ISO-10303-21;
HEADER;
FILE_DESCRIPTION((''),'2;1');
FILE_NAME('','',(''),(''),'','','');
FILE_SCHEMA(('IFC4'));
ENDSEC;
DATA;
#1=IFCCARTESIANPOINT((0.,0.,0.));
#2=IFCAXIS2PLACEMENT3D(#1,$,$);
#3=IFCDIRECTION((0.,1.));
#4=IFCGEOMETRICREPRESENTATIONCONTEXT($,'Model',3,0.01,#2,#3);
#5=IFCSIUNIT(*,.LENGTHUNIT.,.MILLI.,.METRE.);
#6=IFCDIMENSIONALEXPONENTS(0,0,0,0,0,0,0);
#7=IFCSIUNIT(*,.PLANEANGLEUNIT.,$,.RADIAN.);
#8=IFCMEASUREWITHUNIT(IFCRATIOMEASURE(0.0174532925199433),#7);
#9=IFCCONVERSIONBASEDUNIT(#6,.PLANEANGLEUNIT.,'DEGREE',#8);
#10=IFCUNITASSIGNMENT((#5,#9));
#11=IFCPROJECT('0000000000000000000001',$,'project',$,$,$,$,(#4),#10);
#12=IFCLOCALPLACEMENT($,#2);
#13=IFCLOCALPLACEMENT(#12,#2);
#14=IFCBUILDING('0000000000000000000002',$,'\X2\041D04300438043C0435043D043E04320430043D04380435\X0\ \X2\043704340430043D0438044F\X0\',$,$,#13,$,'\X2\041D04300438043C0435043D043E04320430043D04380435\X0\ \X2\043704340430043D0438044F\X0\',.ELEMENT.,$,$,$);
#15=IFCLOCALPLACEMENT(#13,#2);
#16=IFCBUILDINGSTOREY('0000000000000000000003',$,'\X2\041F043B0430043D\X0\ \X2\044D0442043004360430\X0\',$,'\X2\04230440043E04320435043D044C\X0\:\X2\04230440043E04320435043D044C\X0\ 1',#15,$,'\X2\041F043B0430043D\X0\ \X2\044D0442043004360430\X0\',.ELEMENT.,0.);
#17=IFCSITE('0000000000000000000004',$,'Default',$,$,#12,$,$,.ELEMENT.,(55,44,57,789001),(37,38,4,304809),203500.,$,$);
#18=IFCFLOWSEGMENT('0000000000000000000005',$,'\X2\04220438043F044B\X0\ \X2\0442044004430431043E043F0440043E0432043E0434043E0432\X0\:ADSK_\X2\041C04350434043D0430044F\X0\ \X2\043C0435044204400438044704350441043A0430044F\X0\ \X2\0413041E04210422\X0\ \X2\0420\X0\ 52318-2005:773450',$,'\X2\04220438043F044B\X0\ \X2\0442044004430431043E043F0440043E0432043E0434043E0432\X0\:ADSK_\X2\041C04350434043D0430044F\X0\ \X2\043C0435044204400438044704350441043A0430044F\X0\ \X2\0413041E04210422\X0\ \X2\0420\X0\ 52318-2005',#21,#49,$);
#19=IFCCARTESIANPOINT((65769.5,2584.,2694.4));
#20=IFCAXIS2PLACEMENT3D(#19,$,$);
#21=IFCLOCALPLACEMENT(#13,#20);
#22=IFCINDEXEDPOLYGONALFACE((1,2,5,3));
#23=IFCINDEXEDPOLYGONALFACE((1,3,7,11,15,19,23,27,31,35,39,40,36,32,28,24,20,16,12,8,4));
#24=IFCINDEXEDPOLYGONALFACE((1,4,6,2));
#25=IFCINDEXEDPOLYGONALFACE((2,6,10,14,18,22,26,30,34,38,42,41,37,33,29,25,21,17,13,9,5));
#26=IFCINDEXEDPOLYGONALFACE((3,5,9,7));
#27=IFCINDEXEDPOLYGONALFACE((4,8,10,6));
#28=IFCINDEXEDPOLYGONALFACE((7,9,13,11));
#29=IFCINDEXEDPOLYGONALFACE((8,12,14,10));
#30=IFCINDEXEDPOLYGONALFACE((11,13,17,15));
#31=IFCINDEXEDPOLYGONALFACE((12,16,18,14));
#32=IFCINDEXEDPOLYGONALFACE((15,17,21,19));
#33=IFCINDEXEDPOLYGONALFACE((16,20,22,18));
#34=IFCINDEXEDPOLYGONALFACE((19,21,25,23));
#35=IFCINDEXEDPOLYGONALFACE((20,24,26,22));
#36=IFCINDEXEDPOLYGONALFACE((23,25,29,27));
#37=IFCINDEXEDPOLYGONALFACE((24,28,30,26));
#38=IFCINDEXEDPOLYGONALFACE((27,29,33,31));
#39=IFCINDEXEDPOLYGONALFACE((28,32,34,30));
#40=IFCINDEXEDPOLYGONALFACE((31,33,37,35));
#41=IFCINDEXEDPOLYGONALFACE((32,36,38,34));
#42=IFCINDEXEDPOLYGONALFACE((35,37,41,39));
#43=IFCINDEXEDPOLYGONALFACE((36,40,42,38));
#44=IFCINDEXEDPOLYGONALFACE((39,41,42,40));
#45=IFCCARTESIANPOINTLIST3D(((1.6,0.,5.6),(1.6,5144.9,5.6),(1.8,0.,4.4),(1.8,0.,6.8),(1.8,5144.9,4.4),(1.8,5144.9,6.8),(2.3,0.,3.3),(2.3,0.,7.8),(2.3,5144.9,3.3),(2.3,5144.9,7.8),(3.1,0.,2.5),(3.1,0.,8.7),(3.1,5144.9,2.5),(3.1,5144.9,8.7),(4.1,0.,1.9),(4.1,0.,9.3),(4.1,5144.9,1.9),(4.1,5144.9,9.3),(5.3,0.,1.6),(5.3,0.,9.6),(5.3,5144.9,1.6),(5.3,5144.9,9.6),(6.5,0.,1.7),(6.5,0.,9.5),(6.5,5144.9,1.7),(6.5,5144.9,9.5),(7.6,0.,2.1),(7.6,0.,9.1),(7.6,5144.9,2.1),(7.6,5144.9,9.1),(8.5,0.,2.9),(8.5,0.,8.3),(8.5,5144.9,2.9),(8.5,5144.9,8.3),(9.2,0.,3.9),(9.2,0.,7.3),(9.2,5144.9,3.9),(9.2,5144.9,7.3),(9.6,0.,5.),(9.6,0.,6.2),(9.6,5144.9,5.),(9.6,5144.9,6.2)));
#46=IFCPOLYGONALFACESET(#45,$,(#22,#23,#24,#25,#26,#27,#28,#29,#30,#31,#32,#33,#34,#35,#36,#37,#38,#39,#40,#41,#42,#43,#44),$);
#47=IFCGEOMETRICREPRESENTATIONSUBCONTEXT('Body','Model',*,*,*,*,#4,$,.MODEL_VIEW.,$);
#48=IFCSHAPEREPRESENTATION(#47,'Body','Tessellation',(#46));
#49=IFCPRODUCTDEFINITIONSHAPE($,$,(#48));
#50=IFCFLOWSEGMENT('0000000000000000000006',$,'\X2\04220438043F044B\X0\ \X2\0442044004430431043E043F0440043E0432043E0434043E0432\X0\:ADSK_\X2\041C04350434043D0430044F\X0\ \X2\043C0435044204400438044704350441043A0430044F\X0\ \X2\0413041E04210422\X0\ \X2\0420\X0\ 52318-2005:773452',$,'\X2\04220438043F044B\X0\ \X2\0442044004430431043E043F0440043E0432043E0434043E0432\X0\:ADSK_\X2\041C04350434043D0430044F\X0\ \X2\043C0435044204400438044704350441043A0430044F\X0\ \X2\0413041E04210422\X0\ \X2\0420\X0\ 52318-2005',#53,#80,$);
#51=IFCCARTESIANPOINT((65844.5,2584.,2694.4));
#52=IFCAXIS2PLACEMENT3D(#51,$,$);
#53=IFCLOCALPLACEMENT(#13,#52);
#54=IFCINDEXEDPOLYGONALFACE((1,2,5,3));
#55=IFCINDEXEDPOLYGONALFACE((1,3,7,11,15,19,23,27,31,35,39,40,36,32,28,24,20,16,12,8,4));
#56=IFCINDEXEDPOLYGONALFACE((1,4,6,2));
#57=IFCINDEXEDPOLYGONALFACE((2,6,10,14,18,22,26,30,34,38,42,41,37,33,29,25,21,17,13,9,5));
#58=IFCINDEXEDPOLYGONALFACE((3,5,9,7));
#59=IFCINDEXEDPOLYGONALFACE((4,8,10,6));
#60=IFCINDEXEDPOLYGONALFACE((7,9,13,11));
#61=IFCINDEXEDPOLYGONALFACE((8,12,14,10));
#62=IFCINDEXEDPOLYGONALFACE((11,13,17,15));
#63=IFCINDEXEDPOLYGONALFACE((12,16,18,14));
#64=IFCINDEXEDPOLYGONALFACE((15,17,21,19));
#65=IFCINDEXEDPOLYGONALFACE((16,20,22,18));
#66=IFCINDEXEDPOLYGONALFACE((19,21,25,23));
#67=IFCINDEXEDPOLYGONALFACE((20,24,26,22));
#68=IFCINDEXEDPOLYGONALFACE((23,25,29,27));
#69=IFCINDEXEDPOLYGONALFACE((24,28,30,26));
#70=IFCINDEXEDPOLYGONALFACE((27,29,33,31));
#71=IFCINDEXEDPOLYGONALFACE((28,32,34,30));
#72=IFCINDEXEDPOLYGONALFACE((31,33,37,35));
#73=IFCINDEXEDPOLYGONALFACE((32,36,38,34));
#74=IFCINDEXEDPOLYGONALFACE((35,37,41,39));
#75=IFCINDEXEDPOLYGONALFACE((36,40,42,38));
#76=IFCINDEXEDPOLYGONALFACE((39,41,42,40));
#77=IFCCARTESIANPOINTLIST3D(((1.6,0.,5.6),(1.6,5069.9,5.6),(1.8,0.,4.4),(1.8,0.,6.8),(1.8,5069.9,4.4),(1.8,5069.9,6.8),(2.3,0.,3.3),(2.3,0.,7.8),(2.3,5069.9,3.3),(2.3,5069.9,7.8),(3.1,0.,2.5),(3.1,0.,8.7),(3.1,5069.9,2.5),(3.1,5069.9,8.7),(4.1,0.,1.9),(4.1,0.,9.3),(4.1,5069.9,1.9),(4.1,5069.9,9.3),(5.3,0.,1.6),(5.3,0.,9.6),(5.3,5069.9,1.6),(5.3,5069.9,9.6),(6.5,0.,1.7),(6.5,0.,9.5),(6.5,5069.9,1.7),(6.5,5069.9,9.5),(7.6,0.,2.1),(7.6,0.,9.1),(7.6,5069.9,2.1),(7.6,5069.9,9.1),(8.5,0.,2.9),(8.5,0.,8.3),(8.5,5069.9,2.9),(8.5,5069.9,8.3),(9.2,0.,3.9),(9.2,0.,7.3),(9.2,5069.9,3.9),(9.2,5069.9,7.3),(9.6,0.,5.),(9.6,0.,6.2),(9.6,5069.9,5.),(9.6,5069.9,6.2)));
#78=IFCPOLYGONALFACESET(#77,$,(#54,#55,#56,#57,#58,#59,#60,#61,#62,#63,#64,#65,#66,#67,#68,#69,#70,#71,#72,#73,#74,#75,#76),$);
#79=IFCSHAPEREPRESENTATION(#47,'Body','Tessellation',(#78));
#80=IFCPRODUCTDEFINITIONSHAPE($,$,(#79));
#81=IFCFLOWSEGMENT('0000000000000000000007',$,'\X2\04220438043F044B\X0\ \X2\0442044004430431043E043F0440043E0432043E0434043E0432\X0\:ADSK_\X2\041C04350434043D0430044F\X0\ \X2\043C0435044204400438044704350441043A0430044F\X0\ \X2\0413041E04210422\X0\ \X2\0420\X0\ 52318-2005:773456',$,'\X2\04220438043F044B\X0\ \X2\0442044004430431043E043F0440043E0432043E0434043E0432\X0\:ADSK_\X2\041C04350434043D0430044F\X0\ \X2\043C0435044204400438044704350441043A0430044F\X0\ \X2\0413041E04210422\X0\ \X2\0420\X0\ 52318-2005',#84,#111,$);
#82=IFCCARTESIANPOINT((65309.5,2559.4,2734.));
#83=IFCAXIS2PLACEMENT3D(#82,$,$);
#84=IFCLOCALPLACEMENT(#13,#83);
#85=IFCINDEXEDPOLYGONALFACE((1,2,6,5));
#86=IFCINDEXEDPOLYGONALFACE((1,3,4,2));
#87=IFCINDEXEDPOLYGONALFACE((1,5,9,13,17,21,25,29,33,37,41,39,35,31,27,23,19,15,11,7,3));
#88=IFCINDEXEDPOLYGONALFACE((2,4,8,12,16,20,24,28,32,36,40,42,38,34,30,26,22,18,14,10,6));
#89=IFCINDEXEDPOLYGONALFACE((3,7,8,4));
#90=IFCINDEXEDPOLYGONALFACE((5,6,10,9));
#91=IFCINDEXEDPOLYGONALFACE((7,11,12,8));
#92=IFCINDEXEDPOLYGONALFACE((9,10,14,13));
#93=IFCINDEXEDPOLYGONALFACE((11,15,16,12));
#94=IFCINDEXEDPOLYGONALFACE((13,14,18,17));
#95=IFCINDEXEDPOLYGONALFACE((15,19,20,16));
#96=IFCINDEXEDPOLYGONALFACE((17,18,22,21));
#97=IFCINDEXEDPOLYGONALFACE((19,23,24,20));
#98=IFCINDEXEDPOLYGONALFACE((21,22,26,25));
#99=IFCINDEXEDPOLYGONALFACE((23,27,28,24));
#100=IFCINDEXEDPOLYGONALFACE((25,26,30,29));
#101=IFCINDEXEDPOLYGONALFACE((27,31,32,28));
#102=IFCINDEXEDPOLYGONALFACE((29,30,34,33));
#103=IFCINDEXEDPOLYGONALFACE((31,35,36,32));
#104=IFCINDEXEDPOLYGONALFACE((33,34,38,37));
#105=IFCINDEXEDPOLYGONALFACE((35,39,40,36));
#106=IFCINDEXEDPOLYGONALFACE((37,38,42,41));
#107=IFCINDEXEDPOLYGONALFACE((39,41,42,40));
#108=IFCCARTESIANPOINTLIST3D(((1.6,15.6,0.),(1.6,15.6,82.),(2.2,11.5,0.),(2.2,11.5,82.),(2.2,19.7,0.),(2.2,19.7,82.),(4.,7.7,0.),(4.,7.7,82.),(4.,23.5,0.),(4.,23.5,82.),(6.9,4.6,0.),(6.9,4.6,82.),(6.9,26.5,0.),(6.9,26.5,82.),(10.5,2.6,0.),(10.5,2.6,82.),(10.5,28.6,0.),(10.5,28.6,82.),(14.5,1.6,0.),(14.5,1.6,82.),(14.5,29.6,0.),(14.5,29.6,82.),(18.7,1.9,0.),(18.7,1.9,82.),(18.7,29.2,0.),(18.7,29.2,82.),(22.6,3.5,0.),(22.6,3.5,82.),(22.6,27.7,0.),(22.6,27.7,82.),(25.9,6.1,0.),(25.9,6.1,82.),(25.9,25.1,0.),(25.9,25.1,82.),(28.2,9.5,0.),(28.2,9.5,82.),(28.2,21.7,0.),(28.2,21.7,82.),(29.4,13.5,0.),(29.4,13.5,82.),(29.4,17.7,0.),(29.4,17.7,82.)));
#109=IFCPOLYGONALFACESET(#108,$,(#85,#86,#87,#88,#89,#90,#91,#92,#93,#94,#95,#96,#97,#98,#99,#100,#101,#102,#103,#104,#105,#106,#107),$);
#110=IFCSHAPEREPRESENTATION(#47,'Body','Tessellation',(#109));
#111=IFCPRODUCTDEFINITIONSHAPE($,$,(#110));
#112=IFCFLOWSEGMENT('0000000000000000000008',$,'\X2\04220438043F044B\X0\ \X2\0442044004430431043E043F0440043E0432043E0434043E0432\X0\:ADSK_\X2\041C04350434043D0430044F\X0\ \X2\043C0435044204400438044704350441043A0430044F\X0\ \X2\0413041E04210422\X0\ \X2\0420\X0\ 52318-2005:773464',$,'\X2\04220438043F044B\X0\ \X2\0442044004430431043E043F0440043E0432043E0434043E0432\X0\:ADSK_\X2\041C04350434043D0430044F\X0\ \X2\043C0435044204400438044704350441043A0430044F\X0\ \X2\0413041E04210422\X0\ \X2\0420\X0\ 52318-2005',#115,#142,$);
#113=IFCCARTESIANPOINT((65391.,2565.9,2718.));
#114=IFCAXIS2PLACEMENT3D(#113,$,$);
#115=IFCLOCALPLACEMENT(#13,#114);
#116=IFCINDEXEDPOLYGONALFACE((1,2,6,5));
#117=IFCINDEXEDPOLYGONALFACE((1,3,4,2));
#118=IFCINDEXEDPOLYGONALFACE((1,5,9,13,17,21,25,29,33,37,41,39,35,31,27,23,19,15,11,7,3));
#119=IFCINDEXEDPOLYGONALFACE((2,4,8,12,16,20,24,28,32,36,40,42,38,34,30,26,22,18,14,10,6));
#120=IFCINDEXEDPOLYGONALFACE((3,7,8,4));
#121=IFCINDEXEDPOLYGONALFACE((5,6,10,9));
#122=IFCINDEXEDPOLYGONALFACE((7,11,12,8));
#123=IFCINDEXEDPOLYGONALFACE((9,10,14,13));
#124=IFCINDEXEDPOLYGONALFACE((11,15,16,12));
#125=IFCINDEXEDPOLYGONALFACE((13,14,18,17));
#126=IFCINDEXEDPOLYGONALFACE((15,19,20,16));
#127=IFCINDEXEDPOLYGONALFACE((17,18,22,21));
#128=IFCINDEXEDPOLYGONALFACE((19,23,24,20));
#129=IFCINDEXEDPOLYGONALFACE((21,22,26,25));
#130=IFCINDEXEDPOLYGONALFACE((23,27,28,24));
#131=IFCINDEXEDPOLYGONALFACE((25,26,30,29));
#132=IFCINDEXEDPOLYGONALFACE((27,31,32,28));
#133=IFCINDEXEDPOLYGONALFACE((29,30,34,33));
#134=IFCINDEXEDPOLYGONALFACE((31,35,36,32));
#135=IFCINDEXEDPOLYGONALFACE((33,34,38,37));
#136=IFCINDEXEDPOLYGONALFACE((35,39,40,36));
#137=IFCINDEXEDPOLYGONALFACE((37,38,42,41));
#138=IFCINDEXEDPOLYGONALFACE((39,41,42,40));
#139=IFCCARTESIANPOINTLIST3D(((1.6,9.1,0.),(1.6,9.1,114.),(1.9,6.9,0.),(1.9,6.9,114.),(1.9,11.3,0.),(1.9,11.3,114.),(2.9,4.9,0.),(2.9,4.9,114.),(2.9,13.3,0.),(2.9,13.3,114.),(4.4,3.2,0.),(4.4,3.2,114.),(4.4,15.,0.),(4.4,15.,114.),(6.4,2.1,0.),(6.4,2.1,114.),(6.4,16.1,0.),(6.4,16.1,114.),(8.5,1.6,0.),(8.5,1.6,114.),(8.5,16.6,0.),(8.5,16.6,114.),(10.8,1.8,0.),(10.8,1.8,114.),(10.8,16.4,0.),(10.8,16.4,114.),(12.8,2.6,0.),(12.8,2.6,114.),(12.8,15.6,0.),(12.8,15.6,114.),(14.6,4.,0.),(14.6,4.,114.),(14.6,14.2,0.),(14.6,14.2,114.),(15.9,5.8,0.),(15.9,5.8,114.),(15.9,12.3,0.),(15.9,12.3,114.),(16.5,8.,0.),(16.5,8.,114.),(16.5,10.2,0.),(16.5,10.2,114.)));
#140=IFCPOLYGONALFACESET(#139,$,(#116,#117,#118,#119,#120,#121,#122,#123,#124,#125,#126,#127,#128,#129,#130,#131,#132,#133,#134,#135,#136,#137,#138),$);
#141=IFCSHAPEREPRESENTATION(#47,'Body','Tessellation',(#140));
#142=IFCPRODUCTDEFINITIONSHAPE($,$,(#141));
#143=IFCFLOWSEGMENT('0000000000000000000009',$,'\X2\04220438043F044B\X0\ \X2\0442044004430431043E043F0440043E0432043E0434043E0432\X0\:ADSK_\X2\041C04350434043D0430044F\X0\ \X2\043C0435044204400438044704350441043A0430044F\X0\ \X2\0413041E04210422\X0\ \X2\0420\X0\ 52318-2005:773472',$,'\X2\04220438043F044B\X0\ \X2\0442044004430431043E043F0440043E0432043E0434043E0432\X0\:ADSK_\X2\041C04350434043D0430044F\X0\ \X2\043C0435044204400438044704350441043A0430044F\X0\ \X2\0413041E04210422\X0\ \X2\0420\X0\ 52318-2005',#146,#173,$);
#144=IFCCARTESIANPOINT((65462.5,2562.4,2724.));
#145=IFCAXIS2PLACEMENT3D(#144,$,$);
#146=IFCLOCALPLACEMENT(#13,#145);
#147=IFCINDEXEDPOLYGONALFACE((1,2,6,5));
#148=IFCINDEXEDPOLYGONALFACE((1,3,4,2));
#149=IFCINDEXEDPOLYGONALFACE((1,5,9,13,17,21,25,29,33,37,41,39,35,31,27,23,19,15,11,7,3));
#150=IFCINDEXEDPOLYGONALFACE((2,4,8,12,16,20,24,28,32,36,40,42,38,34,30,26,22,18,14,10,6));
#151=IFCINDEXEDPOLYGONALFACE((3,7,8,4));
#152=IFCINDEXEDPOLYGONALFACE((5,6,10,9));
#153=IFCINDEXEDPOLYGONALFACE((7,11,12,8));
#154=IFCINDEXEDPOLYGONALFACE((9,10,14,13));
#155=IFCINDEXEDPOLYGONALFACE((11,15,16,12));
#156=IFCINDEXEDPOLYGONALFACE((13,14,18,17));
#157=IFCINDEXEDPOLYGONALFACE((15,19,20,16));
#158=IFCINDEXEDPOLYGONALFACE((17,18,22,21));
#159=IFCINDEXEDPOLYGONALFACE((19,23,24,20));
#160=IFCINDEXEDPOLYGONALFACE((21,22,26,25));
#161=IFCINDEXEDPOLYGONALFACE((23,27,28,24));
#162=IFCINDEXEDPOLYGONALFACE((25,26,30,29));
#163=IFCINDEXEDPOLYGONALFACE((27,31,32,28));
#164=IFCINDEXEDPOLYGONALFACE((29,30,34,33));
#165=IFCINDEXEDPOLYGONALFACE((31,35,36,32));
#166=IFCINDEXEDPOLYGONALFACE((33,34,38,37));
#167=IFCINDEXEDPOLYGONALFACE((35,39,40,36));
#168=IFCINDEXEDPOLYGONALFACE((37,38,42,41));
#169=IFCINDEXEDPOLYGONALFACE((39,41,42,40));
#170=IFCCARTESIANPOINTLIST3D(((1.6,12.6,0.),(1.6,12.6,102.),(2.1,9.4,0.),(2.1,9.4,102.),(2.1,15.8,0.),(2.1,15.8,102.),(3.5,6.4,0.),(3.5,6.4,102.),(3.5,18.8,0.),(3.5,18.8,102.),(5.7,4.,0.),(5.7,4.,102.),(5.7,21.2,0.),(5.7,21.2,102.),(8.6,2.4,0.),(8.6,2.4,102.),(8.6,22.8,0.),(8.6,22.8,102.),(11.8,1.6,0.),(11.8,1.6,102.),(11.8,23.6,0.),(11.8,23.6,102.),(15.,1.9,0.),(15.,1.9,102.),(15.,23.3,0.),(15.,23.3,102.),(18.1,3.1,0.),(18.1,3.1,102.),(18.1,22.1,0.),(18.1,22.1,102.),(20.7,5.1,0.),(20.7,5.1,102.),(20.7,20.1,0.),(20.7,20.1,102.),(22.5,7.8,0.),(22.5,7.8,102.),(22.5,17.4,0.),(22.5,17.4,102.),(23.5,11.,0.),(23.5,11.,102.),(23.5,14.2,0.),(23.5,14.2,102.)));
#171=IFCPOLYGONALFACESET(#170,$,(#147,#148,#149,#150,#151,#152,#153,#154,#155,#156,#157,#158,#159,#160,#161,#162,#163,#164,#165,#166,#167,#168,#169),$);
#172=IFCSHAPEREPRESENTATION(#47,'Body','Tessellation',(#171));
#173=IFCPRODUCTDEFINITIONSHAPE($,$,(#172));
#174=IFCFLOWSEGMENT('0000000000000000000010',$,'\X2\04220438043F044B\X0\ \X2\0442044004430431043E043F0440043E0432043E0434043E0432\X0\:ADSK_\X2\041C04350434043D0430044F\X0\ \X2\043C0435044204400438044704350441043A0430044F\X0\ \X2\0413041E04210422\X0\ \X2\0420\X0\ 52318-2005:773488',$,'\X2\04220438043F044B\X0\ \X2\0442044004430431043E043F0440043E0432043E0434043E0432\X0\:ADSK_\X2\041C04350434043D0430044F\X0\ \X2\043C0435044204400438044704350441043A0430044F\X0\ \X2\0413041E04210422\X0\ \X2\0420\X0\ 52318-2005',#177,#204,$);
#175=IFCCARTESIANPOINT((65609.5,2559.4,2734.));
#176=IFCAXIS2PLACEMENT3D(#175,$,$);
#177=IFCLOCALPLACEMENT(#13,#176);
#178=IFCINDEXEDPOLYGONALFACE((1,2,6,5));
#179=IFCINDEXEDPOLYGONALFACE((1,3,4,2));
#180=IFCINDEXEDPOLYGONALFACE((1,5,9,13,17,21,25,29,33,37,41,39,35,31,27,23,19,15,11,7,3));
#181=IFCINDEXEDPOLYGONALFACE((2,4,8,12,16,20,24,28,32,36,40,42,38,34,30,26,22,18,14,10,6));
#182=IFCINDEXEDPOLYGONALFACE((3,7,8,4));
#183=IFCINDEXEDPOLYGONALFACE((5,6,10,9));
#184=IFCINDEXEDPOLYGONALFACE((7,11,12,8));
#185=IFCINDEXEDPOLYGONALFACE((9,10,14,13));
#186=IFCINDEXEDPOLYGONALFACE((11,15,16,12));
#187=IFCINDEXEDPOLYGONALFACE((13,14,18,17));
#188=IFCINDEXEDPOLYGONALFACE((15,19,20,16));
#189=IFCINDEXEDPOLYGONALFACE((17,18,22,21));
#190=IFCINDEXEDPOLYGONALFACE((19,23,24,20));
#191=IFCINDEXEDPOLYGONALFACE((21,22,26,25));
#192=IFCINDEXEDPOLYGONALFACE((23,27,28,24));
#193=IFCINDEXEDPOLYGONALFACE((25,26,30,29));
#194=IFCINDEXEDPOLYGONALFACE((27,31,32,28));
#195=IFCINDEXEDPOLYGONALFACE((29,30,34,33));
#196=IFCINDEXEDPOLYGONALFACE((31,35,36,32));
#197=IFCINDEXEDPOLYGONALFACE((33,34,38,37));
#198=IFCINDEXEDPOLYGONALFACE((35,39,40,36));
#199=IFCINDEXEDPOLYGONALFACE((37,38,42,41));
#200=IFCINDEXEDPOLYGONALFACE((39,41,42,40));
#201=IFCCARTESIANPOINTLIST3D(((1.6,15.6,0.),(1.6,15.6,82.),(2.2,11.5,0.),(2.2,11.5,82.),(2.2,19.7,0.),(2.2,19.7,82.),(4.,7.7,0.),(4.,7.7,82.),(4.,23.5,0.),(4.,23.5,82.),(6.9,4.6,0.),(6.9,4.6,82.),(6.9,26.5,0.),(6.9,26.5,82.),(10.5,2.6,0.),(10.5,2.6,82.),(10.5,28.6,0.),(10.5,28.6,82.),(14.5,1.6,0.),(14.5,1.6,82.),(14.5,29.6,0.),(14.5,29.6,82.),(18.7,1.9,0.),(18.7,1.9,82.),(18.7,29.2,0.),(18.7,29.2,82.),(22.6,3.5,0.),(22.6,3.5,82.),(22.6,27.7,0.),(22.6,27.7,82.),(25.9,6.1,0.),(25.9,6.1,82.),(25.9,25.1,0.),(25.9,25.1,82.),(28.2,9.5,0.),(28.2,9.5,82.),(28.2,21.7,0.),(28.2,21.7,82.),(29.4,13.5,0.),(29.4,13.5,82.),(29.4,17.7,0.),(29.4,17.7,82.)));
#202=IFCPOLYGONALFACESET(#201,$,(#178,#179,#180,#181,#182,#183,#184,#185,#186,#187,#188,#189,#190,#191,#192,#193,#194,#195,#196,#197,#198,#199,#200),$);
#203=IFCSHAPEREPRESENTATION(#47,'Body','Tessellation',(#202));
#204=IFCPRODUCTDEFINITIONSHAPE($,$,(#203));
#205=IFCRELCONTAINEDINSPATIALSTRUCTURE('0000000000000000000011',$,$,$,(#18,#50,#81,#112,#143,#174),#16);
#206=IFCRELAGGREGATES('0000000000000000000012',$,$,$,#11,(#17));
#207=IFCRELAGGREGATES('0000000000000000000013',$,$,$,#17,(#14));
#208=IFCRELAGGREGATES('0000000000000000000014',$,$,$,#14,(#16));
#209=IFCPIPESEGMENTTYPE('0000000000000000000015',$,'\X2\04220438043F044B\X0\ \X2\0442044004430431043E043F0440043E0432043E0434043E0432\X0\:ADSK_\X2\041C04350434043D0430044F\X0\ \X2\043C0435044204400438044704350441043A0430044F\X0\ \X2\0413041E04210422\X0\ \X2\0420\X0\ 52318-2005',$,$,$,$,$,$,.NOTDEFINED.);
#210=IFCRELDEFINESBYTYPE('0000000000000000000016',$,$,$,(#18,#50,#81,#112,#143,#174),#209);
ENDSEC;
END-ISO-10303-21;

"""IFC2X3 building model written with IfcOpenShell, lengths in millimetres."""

from ifc_helpers import new_model, entity, si_unit, converted_unit, direction, frame, frame_2d, origin, origin_2d_with_axis, place, context, subcontext, project, spatial, circle, extrude, type_object, element, save


model = new_model("IFC2X3")

# Units and contexts
model_context = context("Model", 3, precision=0.01, world=origin(), true_north=direction((0.0, 1.0)))
body_context = subcontext(model_context, "Body", "Model", "MODEL_VIEW")
ifc_project = project(units=[si_unit("LENGTHUNIT", "METRE", prefix="MILLI"), converted_unit("PLANEANGLEUNIT", "DEGREE", entity("IfcRatioMeasure", 0.0174532925199433), si_unit("PLANEANGLEUNIT", "RADIAN"), dimensions=[0, 0, 0, 0, 0, 0, 0])], contexts=[model_context])

# Site, building, storey
site_placement = place(None, frame((0.0, 0.0, 0.0)))
site = spatial("IfcSite", under=ifc_project, at=site_placement, Name="Default", CompositionType="ELEMENT", RefLatitude=(55, 44, 57, 789001), RefLongitude=(37, 38, 4, 304809), RefElevation=203500.0)
building_placement = place(site_placement, origin())
building = spatial("IfcBuilding", under=site, at=building_placement, Name="Наименование здания", LongName="Наименование здания", CompositionType="ELEMENT")
storey_placement = place(building_placement, origin())
storey = spatial("IfcBuildingStorey", under=building, at=storey_placement, Name="План этажа", ObjectType="Уровень:Уровень 1", LongName="План этажа", CompositionType="ELEMENT", Elevation=0.0)

# Flow segments
pipe_segment_type = type_object("IfcPipeSegmentType", Name="Типы трубопроводов:ADSK_Медная метрическая ГОСТ Р 52318-2005", PredefinedType="NOTDEFINED")
flow_segment_1_placement = place(building_placement, frame((65769.5, 2584.0, 2694.4)))
element("IfcFlowSegment", 1, at=flow_segment_1_placement, inside=storey, type_object=pipe_segment_type, Name="Типы трубопроводов:ADSK_Медная метрическая ГОСТ Р 52318-2005:773450", ObjectType="Типы трубопроводов:ADSK_Медная метрическая ГОСТ Р 52318-2005", context=body_context, shape_type="SweptSolid", body=[
    extrude(circle(Radius=4.0, at=frame_2d((0.0, 0.0), x_axis=(1.0, 0.0))), frame((5.6, 0.0, 5.6), z_axis=(0.0, 1.0, 0.0), x_axis=(-1.0, 0.0, 0.0)), (0.0, 0.0, 1.0), 5144.9),
])
flow_segment_2_placement = place(building_placement, frame((65844.5, 2584.0, 2694.4)))
element("IfcFlowSegment", 2, at=flow_segment_2_placement, inside=storey, type_object=pipe_segment_type, Name="Типы трубопроводов:ADSK_Медная метрическая ГОСТ Р 52318-2005:773452", ObjectType="Типы трубопроводов:ADSK_Медная метрическая ГОСТ Р 52318-2005", context=body_context, shape_type="SweptSolid", body=[
    extrude(circle(Radius=4.0, at=origin_2d_with_axis()), frame((5.6, 0.0, 5.6), z_axis=(0.0, 1.0, 0.0), x_axis=(-1.0, 0.0, 0.0)), (0.0, 0.0, 1.0), 5069.9),
])
flow_segment_3_placement = place(building_placement, frame((65309.5, 2559.4, 2734.0)))
element("IfcFlowSegment", 3, at=flow_segment_3_placement, inside=storey, type_object=pipe_segment_type, Name="Типы трубопроводов:ADSK_Медная метрическая ГОСТ Р 52318-2005:773456", ObjectType="Типы трубопроводов:ADSK_Медная метрическая ГОСТ Р 52318-2005", context=body_context, shape_type="SweptSolid", body=[
    extrude(circle(Radius=14.0, at=origin_2d_with_axis()), frame((15.6, 15.6, 0.0), z_axis=(0.0, 0.0, 1.0), x_axis=(-1.0, 0.0, 0.0)), (0.0, 0.0, 1.0), 82.0),
])
flow_segment_4_placement = place(building_placement, frame((65391.0, 2565.9, 2718.0)))
element("IfcFlowSegment", 4, at=flow_segment_4_placement, inside=storey, type_object=pipe_segment_type, Name="Типы трубопроводов:ADSK_Медная метрическая ГОСТ Р 52318-2005:773464", ObjectType="Типы трубопроводов:ADSK_Медная метрическая ГОСТ Р 52318-2005", context=body_context, shape_type="SweptSolid", body=[
    extrude(circle(Radius=7.5, at=origin_2d_with_axis()), frame((9.1, 9.1, 0.0), z_axis=(0.0, 0.0, 1.0), x_axis=(-1.0, 0.0, 0.0)), (0.0, 0.0, 1.0), 114.0),
])
flow_segment_5_placement = place(building_placement, frame((65462.5, 2562.4, 2724.0)))
element("IfcFlowSegment", 5, at=flow_segment_5_placement, inside=storey, type_object=pipe_segment_type, Name="Типы трубопроводов:ADSK_Медная метрическая ГОСТ Р 52318-2005:773472", ObjectType="Типы трубопроводов:ADSK_Медная метрическая ГОСТ Р 52318-2005", context=body_context, shape_type="SweptSolid", body=[
    extrude(circle(Radius=11.0, at=origin_2d_with_axis()), frame((12.6, 12.6, 0.0), z_axis=(0.0, 0.0, 1.0), x_axis=(-1.0, 0.0, 0.0)), (0.0, 0.0, 1.0), 102.0),
])
flow_segment_6_placement = place(building_placement, frame((65609.5, 2559.4, 2734.0)))
element("IfcFlowSegment", 6, at=flow_segment_6_placement, inside=storey, type_object=pipe_segment_type, Name="Типы трубопроводов:ADSK_Медная метрическая ГОСТ Р 52318-2005:773488", ObjectType="Типы трубопроводов:ADSK_Медная метрическая ГОСТ Р 52318-2005", context=body_context, shape_type="SweptSolid", body=[
    extrude(circle(Radius=14.0, at=origin_2d_with_axis()), frame((15.6, 15.6, 0.0), z_axis=(0.0, 0.0, 1.0), x_axis=(-1.0, 0.0, 0.0)), (0.0, 0.0, 1.0), 82.0),
])

save(model, "model.ifc")
